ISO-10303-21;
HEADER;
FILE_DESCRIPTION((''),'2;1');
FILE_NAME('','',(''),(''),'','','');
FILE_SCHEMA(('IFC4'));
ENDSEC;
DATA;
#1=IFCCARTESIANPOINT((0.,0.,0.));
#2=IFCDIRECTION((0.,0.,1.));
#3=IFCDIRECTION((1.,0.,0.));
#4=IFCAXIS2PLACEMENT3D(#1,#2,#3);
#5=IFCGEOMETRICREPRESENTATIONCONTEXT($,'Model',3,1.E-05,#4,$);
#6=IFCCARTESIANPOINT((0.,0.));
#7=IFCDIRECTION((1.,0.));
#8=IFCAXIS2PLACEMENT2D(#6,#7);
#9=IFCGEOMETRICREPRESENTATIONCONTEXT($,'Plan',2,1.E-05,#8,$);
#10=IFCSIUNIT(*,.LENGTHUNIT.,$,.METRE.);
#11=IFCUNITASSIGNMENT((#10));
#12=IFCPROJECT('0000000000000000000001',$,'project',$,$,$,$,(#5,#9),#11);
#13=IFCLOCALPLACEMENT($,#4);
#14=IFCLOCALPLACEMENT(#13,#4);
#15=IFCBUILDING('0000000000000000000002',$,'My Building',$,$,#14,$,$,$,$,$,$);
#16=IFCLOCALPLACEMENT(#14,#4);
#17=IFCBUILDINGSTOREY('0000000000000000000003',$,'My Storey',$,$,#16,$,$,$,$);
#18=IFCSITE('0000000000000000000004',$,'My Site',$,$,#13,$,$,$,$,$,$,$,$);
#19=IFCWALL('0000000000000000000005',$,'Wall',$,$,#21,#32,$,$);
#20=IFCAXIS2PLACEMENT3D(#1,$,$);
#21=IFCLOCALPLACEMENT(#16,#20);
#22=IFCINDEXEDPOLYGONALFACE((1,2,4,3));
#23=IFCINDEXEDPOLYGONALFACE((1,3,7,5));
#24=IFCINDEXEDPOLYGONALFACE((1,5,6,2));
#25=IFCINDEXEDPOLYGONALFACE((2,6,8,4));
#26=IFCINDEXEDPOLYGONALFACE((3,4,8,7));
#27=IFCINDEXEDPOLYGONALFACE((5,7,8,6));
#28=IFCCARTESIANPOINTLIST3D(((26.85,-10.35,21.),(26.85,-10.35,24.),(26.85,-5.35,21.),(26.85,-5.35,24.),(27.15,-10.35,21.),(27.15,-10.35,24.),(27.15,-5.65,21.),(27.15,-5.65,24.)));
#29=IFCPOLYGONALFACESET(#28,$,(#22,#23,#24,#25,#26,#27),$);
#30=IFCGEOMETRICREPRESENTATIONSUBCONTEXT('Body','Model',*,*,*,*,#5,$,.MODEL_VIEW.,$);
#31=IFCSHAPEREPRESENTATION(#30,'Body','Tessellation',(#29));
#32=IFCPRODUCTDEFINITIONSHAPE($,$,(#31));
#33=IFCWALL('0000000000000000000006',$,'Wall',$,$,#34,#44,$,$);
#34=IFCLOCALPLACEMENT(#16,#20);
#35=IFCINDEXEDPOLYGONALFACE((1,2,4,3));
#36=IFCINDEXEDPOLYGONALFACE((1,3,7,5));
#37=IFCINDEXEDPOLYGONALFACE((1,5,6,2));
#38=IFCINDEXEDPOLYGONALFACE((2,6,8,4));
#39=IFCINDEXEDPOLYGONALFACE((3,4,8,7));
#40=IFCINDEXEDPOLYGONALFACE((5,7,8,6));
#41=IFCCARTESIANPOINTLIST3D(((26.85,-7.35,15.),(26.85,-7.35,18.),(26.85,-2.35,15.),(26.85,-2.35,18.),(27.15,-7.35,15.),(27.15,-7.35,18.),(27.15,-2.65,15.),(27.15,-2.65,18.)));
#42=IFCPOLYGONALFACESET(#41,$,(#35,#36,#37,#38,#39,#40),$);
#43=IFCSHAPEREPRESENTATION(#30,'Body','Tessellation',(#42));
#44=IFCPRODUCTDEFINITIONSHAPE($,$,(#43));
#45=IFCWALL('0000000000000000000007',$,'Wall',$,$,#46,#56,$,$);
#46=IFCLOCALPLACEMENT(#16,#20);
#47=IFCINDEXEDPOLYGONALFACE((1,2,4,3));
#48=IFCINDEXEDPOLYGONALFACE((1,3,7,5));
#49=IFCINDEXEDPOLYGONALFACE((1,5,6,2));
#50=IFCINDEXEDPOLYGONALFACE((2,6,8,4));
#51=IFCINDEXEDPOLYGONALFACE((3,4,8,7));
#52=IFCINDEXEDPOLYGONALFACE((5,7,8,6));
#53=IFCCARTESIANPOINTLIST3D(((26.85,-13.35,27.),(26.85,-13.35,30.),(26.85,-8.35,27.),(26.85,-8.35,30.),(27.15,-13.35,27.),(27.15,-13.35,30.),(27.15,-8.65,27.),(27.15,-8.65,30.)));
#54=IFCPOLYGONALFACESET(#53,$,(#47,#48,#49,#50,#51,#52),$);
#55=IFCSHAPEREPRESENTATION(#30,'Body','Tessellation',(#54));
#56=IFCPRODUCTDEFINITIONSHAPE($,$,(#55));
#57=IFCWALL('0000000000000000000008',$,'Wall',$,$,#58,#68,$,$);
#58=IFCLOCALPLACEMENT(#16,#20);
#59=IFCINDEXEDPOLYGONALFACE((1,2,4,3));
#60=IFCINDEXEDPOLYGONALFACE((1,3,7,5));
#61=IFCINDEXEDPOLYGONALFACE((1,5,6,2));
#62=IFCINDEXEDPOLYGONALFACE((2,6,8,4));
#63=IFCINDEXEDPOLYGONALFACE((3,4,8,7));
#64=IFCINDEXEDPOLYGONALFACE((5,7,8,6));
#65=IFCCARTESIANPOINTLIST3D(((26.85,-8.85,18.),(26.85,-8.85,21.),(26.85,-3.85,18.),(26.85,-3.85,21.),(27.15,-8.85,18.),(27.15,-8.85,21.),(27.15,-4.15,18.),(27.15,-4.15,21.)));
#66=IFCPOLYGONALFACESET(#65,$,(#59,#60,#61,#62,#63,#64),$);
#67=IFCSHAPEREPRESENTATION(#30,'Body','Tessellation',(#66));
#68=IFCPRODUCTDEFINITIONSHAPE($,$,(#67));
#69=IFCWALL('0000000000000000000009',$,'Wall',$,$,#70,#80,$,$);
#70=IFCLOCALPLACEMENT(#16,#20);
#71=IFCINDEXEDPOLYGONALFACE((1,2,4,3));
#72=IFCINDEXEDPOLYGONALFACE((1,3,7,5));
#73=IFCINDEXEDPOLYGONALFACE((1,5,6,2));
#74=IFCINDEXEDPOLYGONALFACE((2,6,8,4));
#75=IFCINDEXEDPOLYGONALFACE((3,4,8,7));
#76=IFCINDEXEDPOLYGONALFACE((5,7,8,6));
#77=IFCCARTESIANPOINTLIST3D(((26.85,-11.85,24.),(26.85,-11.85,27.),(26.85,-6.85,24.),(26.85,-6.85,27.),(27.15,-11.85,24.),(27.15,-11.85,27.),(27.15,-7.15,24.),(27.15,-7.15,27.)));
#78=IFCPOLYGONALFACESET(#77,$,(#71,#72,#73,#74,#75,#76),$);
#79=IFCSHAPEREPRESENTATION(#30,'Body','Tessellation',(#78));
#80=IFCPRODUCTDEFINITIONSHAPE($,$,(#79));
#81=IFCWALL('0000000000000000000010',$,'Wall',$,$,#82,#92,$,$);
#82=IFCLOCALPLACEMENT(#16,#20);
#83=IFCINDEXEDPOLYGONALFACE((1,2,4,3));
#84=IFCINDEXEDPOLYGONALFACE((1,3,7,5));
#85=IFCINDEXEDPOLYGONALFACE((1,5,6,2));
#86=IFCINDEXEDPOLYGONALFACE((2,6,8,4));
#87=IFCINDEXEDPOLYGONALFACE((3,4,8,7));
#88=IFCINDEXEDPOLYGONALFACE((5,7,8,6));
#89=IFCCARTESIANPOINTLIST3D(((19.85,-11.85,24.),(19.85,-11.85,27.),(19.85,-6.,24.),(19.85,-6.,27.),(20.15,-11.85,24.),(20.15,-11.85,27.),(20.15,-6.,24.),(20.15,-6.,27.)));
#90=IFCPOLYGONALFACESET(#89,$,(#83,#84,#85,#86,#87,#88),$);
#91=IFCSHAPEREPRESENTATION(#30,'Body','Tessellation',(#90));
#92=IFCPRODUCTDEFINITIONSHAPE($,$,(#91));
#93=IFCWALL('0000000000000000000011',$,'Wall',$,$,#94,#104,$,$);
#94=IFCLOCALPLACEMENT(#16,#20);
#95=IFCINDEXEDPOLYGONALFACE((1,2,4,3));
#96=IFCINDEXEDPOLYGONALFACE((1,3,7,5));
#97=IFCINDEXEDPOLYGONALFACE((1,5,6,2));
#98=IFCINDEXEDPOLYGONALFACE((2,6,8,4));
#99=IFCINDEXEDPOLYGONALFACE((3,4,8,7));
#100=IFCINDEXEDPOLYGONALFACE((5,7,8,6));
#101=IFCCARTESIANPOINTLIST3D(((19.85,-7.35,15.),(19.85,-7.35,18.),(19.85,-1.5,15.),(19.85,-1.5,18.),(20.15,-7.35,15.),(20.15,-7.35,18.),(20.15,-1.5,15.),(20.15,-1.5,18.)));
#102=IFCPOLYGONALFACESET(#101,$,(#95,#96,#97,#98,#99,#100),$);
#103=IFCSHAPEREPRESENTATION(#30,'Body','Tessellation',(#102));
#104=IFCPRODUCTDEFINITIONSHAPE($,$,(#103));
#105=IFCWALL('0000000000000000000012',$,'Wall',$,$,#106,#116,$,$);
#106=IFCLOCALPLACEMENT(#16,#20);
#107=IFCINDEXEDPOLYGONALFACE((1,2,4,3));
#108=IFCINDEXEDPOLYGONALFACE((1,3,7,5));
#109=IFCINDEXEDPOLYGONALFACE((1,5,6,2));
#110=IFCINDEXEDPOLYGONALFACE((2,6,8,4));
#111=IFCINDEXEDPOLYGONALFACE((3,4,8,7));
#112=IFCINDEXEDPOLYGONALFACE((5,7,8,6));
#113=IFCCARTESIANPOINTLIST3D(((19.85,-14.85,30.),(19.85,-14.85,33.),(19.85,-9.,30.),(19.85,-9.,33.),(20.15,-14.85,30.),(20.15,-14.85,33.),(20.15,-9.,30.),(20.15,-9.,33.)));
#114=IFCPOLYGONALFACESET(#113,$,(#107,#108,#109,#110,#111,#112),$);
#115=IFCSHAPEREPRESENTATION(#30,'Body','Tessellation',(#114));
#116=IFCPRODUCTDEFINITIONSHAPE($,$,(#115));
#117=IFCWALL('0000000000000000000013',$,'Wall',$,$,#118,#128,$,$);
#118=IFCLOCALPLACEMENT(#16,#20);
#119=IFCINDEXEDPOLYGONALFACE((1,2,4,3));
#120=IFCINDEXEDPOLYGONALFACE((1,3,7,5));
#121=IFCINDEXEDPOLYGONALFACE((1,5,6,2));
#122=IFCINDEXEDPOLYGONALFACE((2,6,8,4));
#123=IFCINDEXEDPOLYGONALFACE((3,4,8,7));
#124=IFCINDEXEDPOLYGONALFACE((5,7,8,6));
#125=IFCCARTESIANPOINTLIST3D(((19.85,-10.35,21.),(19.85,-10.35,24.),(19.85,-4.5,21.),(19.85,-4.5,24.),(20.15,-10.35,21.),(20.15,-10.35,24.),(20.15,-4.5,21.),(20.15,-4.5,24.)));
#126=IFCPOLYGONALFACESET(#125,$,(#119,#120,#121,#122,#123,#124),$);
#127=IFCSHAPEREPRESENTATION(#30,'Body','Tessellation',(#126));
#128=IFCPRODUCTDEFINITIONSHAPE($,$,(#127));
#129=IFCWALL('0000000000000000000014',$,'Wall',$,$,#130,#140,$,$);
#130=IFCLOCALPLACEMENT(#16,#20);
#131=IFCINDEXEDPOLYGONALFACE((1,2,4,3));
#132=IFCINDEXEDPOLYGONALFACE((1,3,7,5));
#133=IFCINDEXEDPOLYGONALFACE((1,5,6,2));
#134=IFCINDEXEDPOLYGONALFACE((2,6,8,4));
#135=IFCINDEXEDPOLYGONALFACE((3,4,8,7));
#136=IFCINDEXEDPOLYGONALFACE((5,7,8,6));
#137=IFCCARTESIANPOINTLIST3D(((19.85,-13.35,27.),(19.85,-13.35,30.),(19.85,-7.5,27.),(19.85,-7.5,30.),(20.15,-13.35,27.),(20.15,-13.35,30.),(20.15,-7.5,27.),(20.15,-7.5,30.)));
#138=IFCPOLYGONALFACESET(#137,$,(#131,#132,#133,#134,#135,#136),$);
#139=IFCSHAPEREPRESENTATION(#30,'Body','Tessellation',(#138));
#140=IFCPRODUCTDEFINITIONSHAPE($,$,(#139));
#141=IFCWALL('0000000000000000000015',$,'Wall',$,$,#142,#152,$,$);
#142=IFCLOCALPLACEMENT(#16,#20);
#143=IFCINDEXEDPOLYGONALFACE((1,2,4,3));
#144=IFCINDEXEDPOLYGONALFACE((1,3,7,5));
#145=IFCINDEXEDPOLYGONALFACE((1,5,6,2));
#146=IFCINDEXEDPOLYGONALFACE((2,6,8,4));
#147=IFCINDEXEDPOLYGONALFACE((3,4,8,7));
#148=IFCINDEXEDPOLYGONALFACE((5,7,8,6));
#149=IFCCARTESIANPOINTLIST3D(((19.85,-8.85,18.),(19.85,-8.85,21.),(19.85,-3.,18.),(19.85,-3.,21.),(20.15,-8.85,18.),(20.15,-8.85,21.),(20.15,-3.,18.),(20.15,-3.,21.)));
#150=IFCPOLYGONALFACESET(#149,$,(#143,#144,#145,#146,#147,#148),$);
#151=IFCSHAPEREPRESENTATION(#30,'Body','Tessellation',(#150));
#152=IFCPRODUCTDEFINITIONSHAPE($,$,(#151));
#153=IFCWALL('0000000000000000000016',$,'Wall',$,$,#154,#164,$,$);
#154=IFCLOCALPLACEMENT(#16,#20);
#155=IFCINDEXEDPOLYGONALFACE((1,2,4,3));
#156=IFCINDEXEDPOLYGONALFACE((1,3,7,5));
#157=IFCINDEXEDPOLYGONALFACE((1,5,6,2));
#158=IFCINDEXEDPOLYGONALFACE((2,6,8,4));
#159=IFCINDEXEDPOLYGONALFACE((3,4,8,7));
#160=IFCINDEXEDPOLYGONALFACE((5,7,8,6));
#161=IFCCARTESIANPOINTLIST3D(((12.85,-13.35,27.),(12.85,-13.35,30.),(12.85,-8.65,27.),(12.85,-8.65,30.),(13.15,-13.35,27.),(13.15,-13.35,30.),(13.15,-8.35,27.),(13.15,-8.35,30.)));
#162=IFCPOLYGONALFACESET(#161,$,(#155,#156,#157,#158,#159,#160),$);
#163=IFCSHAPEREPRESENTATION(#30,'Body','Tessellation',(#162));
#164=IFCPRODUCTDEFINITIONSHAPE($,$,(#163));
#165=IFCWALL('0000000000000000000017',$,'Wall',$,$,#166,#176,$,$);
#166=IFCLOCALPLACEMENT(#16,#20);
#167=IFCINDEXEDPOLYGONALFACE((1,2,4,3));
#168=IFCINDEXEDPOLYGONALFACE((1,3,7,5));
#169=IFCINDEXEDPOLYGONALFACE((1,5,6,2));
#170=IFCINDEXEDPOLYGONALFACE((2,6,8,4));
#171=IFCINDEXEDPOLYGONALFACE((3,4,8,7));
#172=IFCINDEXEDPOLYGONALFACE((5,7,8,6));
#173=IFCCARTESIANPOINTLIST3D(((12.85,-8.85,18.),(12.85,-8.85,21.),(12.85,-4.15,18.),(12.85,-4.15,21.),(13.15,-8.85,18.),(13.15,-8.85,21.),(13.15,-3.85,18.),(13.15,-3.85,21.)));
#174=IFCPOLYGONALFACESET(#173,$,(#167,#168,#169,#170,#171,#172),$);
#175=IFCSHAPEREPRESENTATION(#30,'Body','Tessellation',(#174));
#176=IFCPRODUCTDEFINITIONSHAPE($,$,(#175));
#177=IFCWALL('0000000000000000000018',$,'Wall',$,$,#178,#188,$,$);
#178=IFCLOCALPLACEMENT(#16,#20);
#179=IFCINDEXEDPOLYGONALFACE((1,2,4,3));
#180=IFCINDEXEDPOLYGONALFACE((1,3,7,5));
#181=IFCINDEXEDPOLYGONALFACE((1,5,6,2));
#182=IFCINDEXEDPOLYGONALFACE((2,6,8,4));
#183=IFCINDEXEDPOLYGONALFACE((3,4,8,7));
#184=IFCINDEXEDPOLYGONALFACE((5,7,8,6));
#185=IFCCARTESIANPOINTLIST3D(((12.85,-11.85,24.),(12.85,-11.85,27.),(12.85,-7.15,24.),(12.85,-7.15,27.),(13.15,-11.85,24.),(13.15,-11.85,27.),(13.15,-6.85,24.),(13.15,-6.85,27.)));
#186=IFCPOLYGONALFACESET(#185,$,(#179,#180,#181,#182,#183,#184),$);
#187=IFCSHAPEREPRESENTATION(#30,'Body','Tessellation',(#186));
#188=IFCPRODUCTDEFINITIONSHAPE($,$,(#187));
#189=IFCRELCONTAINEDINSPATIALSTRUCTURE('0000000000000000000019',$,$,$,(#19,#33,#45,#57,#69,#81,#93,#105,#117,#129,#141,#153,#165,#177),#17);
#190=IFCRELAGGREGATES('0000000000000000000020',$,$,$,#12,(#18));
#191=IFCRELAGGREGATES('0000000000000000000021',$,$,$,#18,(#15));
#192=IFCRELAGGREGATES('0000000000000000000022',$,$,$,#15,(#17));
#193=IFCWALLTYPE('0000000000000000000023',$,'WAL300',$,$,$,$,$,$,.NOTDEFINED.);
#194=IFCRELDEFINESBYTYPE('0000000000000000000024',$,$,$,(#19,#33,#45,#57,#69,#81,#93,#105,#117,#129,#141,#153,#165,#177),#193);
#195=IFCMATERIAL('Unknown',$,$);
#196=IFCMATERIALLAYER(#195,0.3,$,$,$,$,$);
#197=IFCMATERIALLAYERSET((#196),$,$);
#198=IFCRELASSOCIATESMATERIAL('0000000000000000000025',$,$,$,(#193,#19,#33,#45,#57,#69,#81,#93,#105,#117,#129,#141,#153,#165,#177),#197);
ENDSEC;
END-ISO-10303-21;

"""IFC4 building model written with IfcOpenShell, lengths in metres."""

from ifc_helpers import new_model, si_unit, frame, origin_with_axes, origin_2d_with_axis, place, context, subcontext, project, spatial, line, indexed_curve, outline, extrude, material, layer, layer_set, layer_usage, type_object, element, save


model = new_model("IFC4")

# Units and contexts
model_context = context("Model", 3, precision=1e-05, world=origin_with_axes())
plan_context = context("Plan", 2, precision=1e-05, world=origin_2d_with_axis())
body_context = subcontext(model_context, "Body", "Model", "MODEL_VIEW")
ifc_project = project(units=[si_unit("LENGTHUNIT", "METRE")], contexts=[model_context, plan_context])

# Site, building, storey
site_placement = place(None, origin_with_axes())
site = spatial("IfcSite", under=ifc_project, at=site_placement, Name="My Site")
building_placement = place(site_placement, origin_with_axes())
building = spatial("IfcBuilding", under=site, at=building_placement, Name="My Building")
storey_placement = place(building_placement, origin_with_axes())
storey = spatial("IfcBuildingStorey", under=building, at=storey_placement, Name="My Storey")

# Walls
ifc_material = material(Name="Unknown")
ifc_layer = layer(ifc_material, 0.3)
ifc_layer_set = layer_set([ifc_layer])
ifc_layer_usage_1 = layer_usage(ifc_layer_set, "AXIS2", "POSITIVE", -0.15)
wall_type = type_object("IfcWallType", Name="WAL300", PredefinedType="NOTDEFINED", material=ifc_layer_set)
wall_1_placement = place(storey_placement, frame((27.0, -5.5, 21.0), z_axis=(0.0, 0.0, 1.0), x_axis=(0.0, -1.0, 0.0)))
element("IfcWall", 1, at=wall_1_placement, inside=storey, type_object=wall_type, material=ifc_layer_usage_1, Name="Wall", context=body_context, shape_type="SweptSolid", body=[
    extrude(outline(indexed_curve([(-0.15, -0.15), (0.15, 0.15), (4.85, 0.15), (4.85, -0.15)], segments=[line(1, 2, 3, 4, 1)])), origin_with_axes(), (0.0, 0.0, 1.0), 3.0),
])
ifc_layer_usage_2 = layer_usage(ifc_layer_set, "AXIS2", "POSITIVE", -0.15)
wall_2_placement = place(storey_placement, frame((27.0, -2.5, 15.0), z_axis=(0.0, 0.0, 1.0), x_axis=(0.0, -1.0, 0.0)))
element("IfcWall", 2, at=wall_2_placement, inside=storey, type_object=wall_type, material=ifc_layer_usage_2, Name="Wall", context=body_context, shape_type="SweptSolid", body=[
    extrude(outline(indexed_curve([(-0.15, -0.15), (0.15, 0.15), (4.85, 0.15), (4.85, -0.15)], segments=[line(1, 2, 3, 4, 1)])), origin_with_axes(), (0.0, 0.0, 1.0), 3.0),
])
ifc_layer_usage_3 = layer_usage(ifc_layer_set, "AXIS2", "POSITIVE", -0.15)
wall_3_placement = place(storey_placement, frame((27.0, -8.5, 27.0), z_axis=(0.0, 0.0, 1.0), x_axis=(0.0, -1.0, 0.0)))
element("IfcWall", 3, at=wall_3_placement, inside=storey, type_object=wall_type, material=ifc_layer_usage_3, Name="Wall", context=body_context, shape_type="SweptSolid", body=[
    extrude(outline(indexed_curve([(-0.15, -0.15), (0.15, 0.15), (4.85, 0.15), (4.85, -0.15)], segments=[line(1, 2, 3, 4, 1)])), origin_with_axes(), (0.0, 0.0, 1.0), 3.0),
])
ifc_layer_usage_4 = layer_usage(ifc_layer_set, "AXIS2", "POSITIVE", -0.15)
wall_4_placement = place(storey_placement, frame((27.0, -4.0, 18.0), z_axis=(0.0, 0.0, 1.0), x_axis=(0.0, -1.0, 0.0)))
element("IfcWall", 4, at=wall_4_placement, inside=storey, type_object=wall_type, material=ifc_layer_usage_4, Name="Wall", context=body_context, shape_type="SweptSolid", body=[
    extrude(outline(indexed_curve([(-0.15, -0.15), (0.15, 0.15), (4.85, 0.15), (4.85, -0.15)], segments=[line(1, 2, 3, 4, 1)])), origin_with_axes(), (0.0, 0.0, 1.0), 3.0),
])
ifc_layer_usage_5 = layer_usage(ifc_layer_set, "AXIS2", "POSITIVE", -0.15)
wall_5_placement = place(storey_placement, frame((27.0, -7.0, 24.0), z_axis=(0.0, 0.0, 1.0), x_axis=(0.0, -1.0, 0.0)))
element("IfcWall", 5, at=wall_5_placement, inside=storey, type_object=wall_type, material=ifc_layer_usage_5, Name="Wall", context=body_context, shape_type="SweptSolid", body=[
    extrude(outline(indexed_curve([(-0.15, -0.15), (0.15, 0.15), (4.85, 0.15), (4.85, -0.15)], segments=[line(1, 2, 3, 4, 1)])), origin_with_axes(), (0.0, 0.0, 1.0), 3.0),
])
ifc_layer_usage_6 = layer_usage(ifc_layer_set, "AXIS2", "POSITIVE", -0.15)
wall_6_placement = place(storey_placement, frame((20.0, -12.0, 24.0), z_axis=(0.0, 0.0, 1.0), x_axis=(0.0, 1.0, 0.0)))
element("IfcWall", 6, at=wall_6_placement, inside=storey, type_object=wall_type, material=ifc_layer_usage_6, Name="Wall", context=body_context, shape_type="SweptSolid", body=[
    extrude(outline(indexed_curve([(0.15, -0.15), (0.15, 0.15), (6.0, 0.15), (6.0, -0.15)], segments=[line(1, 2, 3, 4, 1)])), origin_with_axes(), (0.0, 0.0, 1.0), 3.0),
])
ifc_layer_usage_7 = layer_usage(ifc_layer_set, "AXIS2", "POSITIVE", -0.15)
wall_7_placement = place(storey_placement, frame((20.0, -7.5, 15.0), z_axis=(0.0, 0.0, 1.0), x_axis=(0.0, 1.0, 0.0)))
element("IfcWall", 7, at=wall_7_placement, inside=storey, type_object=wall_type, material=ifc_layer_usage_7, Name="Wall", context=body_context, shape_type="SweptSolid", body=[
    extrude(outline(indexed_curve([(0.15, -0.15), (0.15, 0.15), (6.0, 0.15), (6.0, -0.15)], segments=[line(1, 2, 3, 4, 1)])), origin_with_axes(), (0.0, 0.0, 1.0), 3.0),
])
ifc_layer_usage_8 = layer_usage(ifc_layer_set, "AXIS2", "POSITIVE", -0.15)
wall_8_placement = place(storey_placement, frame((20.0, -15.0, 30.0), z_axis=(0.0, 0.0, 1.0), x_axis=(0.0, 1.0, 0.0)))
element("IfcWall", 8, at=wall_8_placement, inside=storey, type_object=wall_type, material=ifc_layer_usage_8, Name="Wall", context=body_context, shape_type="SweptSolid", body=[
    extrude(outline(indexed_curve([(0.15, -0.15), (0.15, 0.15), (6.0, 0.15), (6.0, -0.15)], segments=[line(1, 2, 3, 4, 1)])), origin_with_axes(), (0.0, 0.0, 1.0), 3.0),
])
ifc_layer_usage_9 = layer_usage(ifc_layer_set, "AXIS2", "POSITIVE", -0.15)
wall_9_placement = place(storey_placement, frame((20.0, -10.5, 21.0), z_axis=(0.0, 0.0, 1.0), x_axis=(0.0, 1.0, 0.0)))
element("IfcWall", 9, at=wall_9_placement, inside=storey, type_object=wall_type, material=ifc_layer_usage_9, Name="Wall", context=body_context, shape_type="SweptSolid", body=[
    extrude(outline(indexed_curve([(0.15, -0.15), (0.15, 0.15), (6.0, 0.15), (6.0, -0.15)], segments=[line(1, 2, 3, 4, 1)])), origin_with_axes(), (0.0, 0.0, 1.0), 3.0),
])
ifc_layer_usage_10 = layer_usage(ifc_layer_set, "AXIS2", "POSITIVE", -0.15)
wall_10_placement = place(storey_placement, frame((20.0, -13.5, 27.0), z_axis=(0.0, 0.0, 1.0), x_axis=(0.0, 1.0, 0.0)))
element("IfcWall", 10, at=wall_10_placement, inside=storey, type_object=wall_type, material=ifc_layer_usage_10, Name="Wall", context=body_context, shape_type="SweptSolid", body=[
    extrude(outline(indexed_curve([(0.15, -0.15), (0.15, 0.15), (6.0, 0.15), (6.0, -0.15)], segments=[line(1, 2, 3, 4, 1)])), origin_with_axes(), (0.0, 0.0, 1.0), 3.0),
])
ifc_layer_usage_11 = layer_usage(ifc_layer_set, "AXIS2", "POSITIVE", -0.15)
wall_11_placement = place(storey_placement, frame((20.0, -9.0, 18.0), z_axis=(0.0, 0.0, 1.0), x_axis=(0.0, 1.0, 0.0)))
element("IfcWall", 11, at=wall_11_placement, inside=storey, type_object=wall_type, material=ifc_layer_usage_11, Name="Wall", context=body_context, shape_type="SweptSolid", body=[
    extrude(outline(indexed_curve([(0.15, -0.15), (0.15, 0.15), (6.0, 0.15), (6.0, -0.15)], segments=[line(1, 2, 3, 4, 1)])), origin_with_axes(), (0.0, 0.0, 1.0), 3.0),
])
ifc_layer_usage_12 = layer_usage(ifc_layer_set, "AXIS2", "POSITIVE", -0.15)
wall_12_placement = place(storey_placement, frame((13.0, -13.5, 27.0), z_axis=(0.0, 0.0, 1.0), x_axis=(0.0, 1.0, 0.0)))
element("IfcWall", 12, at=wall_12_placement, inside=storey, type_object=wall_type, material=ifc_layer_usage_12, Name="Wall", context=body_context, shape_type="SweptSolid", body=[
    extrude(outline(indexed_curve([(0.15, -0.15), (0.15, 0.15), (4.85, 0.15), (5.15, -0.15)], segments=[line(1, 2, 3, 4, 1)])), origin_with_axes(), (0.0, 0.0, 1.0), 3.0),
])
ifc_layer_usage_13 = layer_usage(ifc_layer_set, "AXIS2", "POSITIVE", -0.15)
wall_13_placement = place(storey_placement, frame((13.0, -9.0, 18.0), z_axis=(0.0, 0.0, 1.0), x_axis=(0.0, 1.0, 0.0)))
element("IfcWall", 13, at=wall_13_placement, inside=storey, type_object=wall_type, material=ifc_layer_usage_13, Name="Wall", context=body_context, shape_type="SweptSolid", body=[
    extrude(outline(indexed_curve([(0.15, -0.15), (0.15, 0.15), (4.85, 0.15), (5.15, -0.15)], segments=[line(1, 2, 3, 4, 1)])), origin_with_axes(), (0.0, 0.0, 1.0), 3.0),
])
ifc_layer_usage_14 = layer_usage(ifc_layer_set, "AXIS2", "POSITIVE", -0.15)
wall_14_placement = place(storey_placement, frame((13.0, -12.0, 24.0), z_axis=(0.0, 0.0, 1.0), x_axis=(0.0, 1.0, 0.0)))
element("IfcWall", 14, at=wall_14_placement, inside=storey, type_object=wall_type, material=ifc_layer_usage_14, Name="Wall", context=body_context, shape_type="SweptSolid", body=[
    extrude(outline(indexed_curve([(0.15, -0.15), (0.15, 0.15), (4.85, 0.15), (5.15, -0.15)], segments=[line(1, 2, 3, 4, 1)])), origin_with_axes(), (0.0, 0.0, 1.0), 3.0),
])

save(model, "model.ifc")
